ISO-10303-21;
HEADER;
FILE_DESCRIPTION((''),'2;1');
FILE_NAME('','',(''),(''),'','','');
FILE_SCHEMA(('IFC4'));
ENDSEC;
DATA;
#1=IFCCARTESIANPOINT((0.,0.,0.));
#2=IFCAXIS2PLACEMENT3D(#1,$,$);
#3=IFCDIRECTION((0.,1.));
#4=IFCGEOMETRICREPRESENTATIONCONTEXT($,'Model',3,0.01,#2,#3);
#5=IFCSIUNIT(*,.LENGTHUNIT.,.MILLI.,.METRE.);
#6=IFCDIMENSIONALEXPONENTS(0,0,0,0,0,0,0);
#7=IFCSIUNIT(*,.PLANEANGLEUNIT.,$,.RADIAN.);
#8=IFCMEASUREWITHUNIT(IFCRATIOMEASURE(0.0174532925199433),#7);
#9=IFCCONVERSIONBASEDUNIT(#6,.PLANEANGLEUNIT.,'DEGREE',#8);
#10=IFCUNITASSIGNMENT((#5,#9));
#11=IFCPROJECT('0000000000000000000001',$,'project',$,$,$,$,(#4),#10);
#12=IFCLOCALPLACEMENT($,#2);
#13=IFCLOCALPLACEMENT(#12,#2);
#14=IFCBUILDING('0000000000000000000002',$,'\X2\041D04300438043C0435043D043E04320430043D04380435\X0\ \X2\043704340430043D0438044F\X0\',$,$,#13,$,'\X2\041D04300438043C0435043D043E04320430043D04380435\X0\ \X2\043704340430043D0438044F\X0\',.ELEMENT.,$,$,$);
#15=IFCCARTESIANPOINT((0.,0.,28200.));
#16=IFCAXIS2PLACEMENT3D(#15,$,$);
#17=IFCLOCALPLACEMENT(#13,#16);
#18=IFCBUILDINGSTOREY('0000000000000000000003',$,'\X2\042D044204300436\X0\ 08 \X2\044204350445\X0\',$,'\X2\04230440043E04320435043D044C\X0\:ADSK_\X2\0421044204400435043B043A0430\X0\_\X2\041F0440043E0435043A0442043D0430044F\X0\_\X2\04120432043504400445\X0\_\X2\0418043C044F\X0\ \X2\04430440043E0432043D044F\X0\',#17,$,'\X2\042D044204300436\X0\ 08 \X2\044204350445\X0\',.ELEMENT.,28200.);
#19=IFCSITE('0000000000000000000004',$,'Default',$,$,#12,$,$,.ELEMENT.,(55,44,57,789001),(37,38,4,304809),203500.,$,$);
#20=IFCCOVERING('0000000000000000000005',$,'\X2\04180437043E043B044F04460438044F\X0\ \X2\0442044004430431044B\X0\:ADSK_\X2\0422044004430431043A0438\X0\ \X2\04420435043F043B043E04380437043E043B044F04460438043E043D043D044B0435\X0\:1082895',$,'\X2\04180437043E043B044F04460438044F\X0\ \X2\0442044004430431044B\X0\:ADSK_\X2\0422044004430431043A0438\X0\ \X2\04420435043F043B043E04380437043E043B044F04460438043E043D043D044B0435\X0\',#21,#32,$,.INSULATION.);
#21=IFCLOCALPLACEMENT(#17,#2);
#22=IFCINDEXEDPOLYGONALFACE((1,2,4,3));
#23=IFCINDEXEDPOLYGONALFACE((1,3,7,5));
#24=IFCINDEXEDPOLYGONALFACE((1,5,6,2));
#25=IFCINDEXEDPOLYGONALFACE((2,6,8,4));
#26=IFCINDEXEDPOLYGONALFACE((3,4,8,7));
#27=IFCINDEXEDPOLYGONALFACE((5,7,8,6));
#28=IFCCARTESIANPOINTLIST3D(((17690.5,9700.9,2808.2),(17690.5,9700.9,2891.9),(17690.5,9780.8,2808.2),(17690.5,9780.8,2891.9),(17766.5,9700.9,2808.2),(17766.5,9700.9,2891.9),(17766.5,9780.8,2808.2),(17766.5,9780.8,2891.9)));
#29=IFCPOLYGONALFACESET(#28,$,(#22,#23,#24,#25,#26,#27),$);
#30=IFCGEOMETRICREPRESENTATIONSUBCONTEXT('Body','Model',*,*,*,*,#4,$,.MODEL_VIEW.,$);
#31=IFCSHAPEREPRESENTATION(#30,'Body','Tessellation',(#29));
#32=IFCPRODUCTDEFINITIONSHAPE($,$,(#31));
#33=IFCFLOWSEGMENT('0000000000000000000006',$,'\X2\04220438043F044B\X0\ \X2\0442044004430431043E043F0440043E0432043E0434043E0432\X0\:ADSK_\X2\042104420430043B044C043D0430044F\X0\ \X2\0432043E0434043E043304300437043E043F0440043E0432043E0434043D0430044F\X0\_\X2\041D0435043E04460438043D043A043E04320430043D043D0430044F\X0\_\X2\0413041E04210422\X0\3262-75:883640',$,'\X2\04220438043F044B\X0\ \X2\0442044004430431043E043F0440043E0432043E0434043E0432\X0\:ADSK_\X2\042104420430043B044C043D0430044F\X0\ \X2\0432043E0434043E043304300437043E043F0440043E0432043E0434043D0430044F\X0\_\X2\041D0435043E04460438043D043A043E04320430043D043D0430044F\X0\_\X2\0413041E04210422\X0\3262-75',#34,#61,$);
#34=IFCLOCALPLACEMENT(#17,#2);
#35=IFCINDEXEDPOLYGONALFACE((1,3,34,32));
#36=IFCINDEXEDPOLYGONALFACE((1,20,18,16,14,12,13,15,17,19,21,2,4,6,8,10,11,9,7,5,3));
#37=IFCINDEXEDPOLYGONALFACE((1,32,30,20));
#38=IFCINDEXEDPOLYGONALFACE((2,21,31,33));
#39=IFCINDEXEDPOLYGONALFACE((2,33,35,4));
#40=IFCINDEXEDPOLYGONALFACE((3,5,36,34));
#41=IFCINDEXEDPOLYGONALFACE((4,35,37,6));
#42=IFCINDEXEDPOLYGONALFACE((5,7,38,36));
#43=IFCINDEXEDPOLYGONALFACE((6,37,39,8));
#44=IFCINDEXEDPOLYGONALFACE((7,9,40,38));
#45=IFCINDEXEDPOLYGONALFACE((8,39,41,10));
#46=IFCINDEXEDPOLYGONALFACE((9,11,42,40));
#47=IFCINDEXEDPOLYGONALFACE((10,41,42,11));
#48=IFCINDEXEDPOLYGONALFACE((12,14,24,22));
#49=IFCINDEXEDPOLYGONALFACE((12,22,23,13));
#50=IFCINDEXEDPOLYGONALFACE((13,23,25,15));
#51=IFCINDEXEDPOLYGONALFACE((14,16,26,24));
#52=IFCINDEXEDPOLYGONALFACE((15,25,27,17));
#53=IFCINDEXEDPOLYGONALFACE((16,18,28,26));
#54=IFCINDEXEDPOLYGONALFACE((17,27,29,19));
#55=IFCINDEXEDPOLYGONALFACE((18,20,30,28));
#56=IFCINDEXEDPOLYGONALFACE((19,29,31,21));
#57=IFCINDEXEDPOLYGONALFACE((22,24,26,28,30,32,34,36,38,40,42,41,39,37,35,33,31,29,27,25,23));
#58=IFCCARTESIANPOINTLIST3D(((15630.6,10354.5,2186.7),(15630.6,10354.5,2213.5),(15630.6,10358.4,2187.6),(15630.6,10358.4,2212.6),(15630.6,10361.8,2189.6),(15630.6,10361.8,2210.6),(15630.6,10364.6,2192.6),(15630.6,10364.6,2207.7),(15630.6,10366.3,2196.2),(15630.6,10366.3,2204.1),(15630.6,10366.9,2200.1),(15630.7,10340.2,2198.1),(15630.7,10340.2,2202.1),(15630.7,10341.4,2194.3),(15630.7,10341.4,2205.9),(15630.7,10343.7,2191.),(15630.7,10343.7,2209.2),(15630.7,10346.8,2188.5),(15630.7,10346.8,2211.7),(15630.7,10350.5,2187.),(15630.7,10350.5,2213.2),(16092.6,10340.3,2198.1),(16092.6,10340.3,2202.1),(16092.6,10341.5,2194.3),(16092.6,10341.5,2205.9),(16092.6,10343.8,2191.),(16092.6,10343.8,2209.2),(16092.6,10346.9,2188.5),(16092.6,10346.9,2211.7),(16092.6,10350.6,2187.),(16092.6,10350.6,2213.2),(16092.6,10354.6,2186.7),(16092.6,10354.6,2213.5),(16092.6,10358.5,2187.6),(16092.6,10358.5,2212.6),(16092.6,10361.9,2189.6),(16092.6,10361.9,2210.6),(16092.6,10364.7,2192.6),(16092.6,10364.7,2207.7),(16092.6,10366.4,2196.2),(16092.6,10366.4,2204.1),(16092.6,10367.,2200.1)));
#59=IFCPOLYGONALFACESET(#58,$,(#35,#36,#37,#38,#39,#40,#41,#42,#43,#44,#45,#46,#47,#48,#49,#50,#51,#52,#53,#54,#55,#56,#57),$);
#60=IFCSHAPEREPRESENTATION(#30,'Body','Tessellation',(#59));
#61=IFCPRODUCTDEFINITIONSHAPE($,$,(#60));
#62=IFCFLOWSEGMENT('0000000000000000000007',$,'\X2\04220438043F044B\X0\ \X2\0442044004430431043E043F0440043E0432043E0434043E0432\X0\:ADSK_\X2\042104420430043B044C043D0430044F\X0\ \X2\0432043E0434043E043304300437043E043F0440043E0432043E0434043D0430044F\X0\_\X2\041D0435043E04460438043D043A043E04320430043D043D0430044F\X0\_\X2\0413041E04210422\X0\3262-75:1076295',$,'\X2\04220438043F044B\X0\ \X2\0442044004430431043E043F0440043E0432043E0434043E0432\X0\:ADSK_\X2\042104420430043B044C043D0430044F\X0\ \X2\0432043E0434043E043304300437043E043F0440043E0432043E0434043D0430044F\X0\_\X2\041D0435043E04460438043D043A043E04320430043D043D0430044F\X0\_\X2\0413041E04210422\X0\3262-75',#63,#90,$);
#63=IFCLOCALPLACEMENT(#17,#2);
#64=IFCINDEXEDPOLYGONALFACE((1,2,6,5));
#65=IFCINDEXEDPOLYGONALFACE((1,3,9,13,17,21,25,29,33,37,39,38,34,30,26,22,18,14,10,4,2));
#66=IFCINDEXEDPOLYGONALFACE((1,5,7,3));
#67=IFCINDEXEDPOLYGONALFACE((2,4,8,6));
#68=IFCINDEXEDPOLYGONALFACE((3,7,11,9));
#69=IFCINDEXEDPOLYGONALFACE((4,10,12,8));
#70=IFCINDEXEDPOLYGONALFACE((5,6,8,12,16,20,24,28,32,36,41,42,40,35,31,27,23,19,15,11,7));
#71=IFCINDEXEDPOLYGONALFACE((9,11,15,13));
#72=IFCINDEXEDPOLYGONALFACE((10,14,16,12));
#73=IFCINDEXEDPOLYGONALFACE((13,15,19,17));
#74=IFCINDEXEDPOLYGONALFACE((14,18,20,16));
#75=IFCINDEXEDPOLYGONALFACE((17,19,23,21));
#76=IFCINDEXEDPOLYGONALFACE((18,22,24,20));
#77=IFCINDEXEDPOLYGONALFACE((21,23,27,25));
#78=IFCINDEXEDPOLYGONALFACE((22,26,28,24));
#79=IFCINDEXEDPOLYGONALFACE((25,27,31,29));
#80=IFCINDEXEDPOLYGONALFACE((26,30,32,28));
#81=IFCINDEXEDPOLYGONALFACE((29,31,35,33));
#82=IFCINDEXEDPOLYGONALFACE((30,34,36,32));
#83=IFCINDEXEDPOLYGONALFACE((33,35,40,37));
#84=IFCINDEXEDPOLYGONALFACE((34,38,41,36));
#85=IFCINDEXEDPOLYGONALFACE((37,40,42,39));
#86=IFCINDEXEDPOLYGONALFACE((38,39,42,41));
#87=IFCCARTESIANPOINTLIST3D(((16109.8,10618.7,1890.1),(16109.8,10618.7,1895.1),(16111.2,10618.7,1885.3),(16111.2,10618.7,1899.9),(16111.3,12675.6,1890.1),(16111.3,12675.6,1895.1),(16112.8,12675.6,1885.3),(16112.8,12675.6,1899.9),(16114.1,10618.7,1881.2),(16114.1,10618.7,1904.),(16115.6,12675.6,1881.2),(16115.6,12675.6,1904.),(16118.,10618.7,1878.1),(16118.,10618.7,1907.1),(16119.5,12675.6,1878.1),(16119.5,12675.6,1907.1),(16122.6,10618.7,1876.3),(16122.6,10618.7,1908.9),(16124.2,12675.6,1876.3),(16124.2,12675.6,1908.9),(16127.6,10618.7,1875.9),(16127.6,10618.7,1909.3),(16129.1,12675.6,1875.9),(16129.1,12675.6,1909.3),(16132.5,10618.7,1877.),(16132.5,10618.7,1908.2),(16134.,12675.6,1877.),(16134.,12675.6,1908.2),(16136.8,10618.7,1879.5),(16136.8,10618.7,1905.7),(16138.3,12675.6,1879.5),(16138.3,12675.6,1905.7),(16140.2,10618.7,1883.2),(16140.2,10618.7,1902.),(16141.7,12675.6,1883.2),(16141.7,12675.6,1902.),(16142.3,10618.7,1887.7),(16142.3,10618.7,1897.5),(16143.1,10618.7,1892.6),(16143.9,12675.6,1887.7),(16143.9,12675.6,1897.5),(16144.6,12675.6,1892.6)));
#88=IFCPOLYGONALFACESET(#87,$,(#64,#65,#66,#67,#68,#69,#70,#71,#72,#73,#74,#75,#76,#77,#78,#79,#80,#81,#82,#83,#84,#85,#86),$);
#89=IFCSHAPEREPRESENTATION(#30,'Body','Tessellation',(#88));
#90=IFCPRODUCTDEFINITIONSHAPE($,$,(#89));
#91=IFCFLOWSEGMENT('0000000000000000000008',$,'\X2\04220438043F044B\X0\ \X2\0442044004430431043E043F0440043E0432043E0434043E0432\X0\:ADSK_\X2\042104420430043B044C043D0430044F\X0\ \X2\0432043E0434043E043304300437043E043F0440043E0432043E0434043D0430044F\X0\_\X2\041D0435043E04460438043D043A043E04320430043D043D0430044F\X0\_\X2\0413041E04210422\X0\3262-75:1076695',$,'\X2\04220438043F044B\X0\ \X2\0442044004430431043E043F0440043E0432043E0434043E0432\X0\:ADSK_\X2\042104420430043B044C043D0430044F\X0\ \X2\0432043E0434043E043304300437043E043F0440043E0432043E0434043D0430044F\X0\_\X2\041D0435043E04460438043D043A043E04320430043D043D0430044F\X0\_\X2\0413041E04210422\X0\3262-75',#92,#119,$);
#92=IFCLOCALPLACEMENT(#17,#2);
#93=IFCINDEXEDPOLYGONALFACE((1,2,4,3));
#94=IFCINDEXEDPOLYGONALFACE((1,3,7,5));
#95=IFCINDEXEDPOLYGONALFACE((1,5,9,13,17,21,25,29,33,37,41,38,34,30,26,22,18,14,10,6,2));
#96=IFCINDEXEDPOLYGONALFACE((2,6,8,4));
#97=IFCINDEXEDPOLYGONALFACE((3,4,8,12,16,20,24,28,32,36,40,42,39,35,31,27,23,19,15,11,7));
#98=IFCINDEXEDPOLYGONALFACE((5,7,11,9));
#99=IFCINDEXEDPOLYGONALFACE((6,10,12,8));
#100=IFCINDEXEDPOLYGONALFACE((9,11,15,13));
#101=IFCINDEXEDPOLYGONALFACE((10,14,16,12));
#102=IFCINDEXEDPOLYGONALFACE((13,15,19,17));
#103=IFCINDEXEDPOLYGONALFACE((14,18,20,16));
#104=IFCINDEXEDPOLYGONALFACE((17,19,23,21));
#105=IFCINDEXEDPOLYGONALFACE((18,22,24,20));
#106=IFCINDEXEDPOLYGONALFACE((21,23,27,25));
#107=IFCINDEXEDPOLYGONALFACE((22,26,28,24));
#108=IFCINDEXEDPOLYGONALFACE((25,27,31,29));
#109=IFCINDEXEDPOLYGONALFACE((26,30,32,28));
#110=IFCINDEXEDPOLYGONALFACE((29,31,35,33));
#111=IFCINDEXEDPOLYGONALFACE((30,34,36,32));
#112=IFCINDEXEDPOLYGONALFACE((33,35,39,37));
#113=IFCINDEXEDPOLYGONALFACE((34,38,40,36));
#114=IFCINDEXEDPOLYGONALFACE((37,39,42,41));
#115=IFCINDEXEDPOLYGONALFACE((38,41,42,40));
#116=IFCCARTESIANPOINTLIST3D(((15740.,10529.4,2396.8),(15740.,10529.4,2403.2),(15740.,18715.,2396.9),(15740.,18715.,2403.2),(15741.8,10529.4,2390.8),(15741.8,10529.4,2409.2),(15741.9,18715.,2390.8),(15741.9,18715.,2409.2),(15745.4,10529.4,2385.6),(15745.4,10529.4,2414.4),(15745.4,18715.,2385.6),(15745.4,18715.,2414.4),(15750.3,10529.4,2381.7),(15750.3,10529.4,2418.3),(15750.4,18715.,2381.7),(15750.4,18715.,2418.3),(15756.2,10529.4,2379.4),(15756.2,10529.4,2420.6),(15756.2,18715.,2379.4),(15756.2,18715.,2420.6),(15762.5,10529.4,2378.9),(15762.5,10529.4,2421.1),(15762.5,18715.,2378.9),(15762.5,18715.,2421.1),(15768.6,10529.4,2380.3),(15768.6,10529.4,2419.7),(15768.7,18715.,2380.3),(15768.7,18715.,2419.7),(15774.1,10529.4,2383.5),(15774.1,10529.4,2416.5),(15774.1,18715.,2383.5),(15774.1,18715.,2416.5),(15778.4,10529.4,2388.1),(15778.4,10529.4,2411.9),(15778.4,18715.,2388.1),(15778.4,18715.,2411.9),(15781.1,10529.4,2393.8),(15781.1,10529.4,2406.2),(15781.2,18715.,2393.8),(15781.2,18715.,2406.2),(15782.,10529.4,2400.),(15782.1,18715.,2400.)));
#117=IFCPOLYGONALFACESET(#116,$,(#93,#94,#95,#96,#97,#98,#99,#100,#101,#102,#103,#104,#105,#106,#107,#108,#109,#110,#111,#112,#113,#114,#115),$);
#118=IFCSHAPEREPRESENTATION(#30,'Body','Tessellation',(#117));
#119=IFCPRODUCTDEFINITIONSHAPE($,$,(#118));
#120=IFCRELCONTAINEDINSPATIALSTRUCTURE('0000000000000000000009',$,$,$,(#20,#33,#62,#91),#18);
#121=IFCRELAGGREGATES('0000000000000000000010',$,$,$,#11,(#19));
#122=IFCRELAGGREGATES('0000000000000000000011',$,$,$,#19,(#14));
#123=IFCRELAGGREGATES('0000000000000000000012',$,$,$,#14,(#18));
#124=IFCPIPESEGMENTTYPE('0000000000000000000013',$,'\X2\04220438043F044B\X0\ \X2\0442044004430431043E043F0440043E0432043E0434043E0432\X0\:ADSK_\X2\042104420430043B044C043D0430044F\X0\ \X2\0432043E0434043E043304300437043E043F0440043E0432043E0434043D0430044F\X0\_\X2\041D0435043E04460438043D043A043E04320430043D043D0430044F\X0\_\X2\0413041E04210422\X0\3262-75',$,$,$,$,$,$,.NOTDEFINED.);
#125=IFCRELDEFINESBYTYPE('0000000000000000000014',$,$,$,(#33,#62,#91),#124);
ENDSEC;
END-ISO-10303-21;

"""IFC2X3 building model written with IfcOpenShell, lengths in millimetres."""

from ifc_helpers import new_model, entity, si_unit, converted_unit, direction, frame, origin, origin_2d_with_axis, place, context, subcontext, project, spatial, rectangle, circle, extrude, type_object, element, save


model = new_model("IFC2X3")

# Units and contexts
model_context = context("Model", 3, precision=0.01, world=origin(), true_north=direction((0.0, 1.0)))
body_context = subcontext(model_context, "Body", "Model", "MODEL_VIEW")
ifc_project = project(units=[si_unit("LENGTHUNIT", "METRE", prefix="MILLI"), converted_unit("PLANEANGLEUNIT", "DEGREE", entity("IfcRatioMeasure", 0.0174532925199433), si_unit("PLANEANGLEUNIT", "RADIAN"), dimensions=[0, 0, 0, 0, 0, 0, 0])], contexts=[model_context])

# Site, building, storey
site_placement = place(None, origin())
site = spatial("IfcSite", under=ifc_project, at=site_placement, Name="Default", CompositionType="ELEMENT", RefLatitude=(55, 44, 57, 789001), RefLongitude=(37, 38, 4, 304809), RefElevation=203500.0)
building_placement = place(site_placement, origin())
building = spatial("IfcBuilding", under=site, at=building_placement, Name="Наименование здания", LongName="Наименование здания", CompositionType="ELEMENT")
storey_placement = place(building_placement, frame((0.0, 0.0, 28200.0)))
storey = spatial("IfcBuildingStorey", under=building, at=storey_placement, Name="Этаж 08 тех", ObjectType="Уровень:ADSK_Стрелка_Проектная_Вверх_Имя уровня", LongName="Этаж 08 тех", CompositionType="ELEMENT", Elevation=28200.0)

# Covering
covering_placement = place(storey_placement, frame((17690.5, 9701.0, 2808.2)))
element("IfcCovering", 1, at=covering_placement, inside=storey, Name="Изоляция трубы:ADSK_Трубки теплоизоляционные:1082895", ObjectType="Изоляция трубы:ADSK_Трубки теплоизоляционные", PredefinedType="INSULATION", context=body_context, shape_type="SweptSolid", body=[
    extrude(rectangle(XDim=83.7, YDim=79.8, at=origin_2d_with_axis()), frame((0.0, 39.9, 41.9), z_axis=(1.0, 0.0, -0.000019), x_axis=(-0.000019, 0.0, -1.0)), (-0.000019, 0.0, 1.0), 76.0),
])

# Flow segments
pipe_segment_type = type_object("IfcPipeSegmentType", Name="Типы трубопроводов:ADSK_Стальная водогазопроводная_Неоцинкованная_ГОСТ3262-75", PredefinedType="NOTDEFINED")
flow_segment_1_placement = place(storey_placement, frame((15630.6, 10338.5, 2185.1)))
element("IfcFlowSegment", 2, at=flow_segment_1_placement, inside=storey, type_object=pipe_segment_type, Name="Типы трубопроводов:ADSK_Стальная водогазопроводная_Неоцинкованная_ГОСТ3262-75:883640", ObjectType="Типы трубопроводов:ADSK_Стальная водогазопроводная_Неоцинкованная_ГОСТ3262-75", context=body_context, shape_type="SweptSolid", body=[
    extrude(circle(Radius=13.4, at=origin_2d_with_axis()), frame((0.0, 15.0, 15.0), z_axis=(1.0, 0.00021, 0.0), x_axis=(-0.00021, 1.0, 0.0)), (0.0, 0.0, 1.0), 461.9),
])
flow_segment_2_placement = place(storey_placement, frame((16108.0, 10618.7, 1874.3)))
element("IfcFlowSegment", 3, at=flow_segment_2_placement, inside=storey, type_object=pipe_segment_type, Name="Типы трубопроводов:ADSK_Стальная водогазопроводная_Неоцинкованная_ГОСТ3262-75:1076295", ObjectType="Типы трубопроводов:ADSK_Стальная водогазопроводная_Неоцинкованная_ГОСТ3262-75", context=body_context, shape_type="SweptSolid", body=[
    extrude(circle(Radius=16.8, at=origin_2d_with_axis()), frame((18.4, 0.0, 18.4), z_axis=(0.000748, 1.0, 0.0), x_axis=(1.0, -0.000748, 0.0)), (0.0, 0.0, 1.0), 2056.9),
])
flow_segment_3_placement = place(storey_placement, frame((15738.1, 10529.4, 2377.2)))
element("IfcFlowSegment", 4, at=flow_segment_3_placement, inside=storey, type_object=pipe_segment_type, Name="Типы трубопроводов:ADSK_Стальная водогазопроводная_Неоцинкованная_ГОСТ3262-75:1076695", ObjectType="Типы трубопроводов:ADSK_Стальная водогазопроводная_Неоцинкованная_ГОСТ3262-75", context=body_context, shape_type="SweptSolid", body=[
    extrude(circle(Radius=21.1, at=origin_2d_with_axis()), frame((22.8, 0.0, 22.8), z_axis=(0.000007, 1.0, 0.000001), x_axis=(1.0, -0.000007, 0.0)), (0.0, 0.0, 1.0), 8185.6),
])

save(model, "model.ifc")
